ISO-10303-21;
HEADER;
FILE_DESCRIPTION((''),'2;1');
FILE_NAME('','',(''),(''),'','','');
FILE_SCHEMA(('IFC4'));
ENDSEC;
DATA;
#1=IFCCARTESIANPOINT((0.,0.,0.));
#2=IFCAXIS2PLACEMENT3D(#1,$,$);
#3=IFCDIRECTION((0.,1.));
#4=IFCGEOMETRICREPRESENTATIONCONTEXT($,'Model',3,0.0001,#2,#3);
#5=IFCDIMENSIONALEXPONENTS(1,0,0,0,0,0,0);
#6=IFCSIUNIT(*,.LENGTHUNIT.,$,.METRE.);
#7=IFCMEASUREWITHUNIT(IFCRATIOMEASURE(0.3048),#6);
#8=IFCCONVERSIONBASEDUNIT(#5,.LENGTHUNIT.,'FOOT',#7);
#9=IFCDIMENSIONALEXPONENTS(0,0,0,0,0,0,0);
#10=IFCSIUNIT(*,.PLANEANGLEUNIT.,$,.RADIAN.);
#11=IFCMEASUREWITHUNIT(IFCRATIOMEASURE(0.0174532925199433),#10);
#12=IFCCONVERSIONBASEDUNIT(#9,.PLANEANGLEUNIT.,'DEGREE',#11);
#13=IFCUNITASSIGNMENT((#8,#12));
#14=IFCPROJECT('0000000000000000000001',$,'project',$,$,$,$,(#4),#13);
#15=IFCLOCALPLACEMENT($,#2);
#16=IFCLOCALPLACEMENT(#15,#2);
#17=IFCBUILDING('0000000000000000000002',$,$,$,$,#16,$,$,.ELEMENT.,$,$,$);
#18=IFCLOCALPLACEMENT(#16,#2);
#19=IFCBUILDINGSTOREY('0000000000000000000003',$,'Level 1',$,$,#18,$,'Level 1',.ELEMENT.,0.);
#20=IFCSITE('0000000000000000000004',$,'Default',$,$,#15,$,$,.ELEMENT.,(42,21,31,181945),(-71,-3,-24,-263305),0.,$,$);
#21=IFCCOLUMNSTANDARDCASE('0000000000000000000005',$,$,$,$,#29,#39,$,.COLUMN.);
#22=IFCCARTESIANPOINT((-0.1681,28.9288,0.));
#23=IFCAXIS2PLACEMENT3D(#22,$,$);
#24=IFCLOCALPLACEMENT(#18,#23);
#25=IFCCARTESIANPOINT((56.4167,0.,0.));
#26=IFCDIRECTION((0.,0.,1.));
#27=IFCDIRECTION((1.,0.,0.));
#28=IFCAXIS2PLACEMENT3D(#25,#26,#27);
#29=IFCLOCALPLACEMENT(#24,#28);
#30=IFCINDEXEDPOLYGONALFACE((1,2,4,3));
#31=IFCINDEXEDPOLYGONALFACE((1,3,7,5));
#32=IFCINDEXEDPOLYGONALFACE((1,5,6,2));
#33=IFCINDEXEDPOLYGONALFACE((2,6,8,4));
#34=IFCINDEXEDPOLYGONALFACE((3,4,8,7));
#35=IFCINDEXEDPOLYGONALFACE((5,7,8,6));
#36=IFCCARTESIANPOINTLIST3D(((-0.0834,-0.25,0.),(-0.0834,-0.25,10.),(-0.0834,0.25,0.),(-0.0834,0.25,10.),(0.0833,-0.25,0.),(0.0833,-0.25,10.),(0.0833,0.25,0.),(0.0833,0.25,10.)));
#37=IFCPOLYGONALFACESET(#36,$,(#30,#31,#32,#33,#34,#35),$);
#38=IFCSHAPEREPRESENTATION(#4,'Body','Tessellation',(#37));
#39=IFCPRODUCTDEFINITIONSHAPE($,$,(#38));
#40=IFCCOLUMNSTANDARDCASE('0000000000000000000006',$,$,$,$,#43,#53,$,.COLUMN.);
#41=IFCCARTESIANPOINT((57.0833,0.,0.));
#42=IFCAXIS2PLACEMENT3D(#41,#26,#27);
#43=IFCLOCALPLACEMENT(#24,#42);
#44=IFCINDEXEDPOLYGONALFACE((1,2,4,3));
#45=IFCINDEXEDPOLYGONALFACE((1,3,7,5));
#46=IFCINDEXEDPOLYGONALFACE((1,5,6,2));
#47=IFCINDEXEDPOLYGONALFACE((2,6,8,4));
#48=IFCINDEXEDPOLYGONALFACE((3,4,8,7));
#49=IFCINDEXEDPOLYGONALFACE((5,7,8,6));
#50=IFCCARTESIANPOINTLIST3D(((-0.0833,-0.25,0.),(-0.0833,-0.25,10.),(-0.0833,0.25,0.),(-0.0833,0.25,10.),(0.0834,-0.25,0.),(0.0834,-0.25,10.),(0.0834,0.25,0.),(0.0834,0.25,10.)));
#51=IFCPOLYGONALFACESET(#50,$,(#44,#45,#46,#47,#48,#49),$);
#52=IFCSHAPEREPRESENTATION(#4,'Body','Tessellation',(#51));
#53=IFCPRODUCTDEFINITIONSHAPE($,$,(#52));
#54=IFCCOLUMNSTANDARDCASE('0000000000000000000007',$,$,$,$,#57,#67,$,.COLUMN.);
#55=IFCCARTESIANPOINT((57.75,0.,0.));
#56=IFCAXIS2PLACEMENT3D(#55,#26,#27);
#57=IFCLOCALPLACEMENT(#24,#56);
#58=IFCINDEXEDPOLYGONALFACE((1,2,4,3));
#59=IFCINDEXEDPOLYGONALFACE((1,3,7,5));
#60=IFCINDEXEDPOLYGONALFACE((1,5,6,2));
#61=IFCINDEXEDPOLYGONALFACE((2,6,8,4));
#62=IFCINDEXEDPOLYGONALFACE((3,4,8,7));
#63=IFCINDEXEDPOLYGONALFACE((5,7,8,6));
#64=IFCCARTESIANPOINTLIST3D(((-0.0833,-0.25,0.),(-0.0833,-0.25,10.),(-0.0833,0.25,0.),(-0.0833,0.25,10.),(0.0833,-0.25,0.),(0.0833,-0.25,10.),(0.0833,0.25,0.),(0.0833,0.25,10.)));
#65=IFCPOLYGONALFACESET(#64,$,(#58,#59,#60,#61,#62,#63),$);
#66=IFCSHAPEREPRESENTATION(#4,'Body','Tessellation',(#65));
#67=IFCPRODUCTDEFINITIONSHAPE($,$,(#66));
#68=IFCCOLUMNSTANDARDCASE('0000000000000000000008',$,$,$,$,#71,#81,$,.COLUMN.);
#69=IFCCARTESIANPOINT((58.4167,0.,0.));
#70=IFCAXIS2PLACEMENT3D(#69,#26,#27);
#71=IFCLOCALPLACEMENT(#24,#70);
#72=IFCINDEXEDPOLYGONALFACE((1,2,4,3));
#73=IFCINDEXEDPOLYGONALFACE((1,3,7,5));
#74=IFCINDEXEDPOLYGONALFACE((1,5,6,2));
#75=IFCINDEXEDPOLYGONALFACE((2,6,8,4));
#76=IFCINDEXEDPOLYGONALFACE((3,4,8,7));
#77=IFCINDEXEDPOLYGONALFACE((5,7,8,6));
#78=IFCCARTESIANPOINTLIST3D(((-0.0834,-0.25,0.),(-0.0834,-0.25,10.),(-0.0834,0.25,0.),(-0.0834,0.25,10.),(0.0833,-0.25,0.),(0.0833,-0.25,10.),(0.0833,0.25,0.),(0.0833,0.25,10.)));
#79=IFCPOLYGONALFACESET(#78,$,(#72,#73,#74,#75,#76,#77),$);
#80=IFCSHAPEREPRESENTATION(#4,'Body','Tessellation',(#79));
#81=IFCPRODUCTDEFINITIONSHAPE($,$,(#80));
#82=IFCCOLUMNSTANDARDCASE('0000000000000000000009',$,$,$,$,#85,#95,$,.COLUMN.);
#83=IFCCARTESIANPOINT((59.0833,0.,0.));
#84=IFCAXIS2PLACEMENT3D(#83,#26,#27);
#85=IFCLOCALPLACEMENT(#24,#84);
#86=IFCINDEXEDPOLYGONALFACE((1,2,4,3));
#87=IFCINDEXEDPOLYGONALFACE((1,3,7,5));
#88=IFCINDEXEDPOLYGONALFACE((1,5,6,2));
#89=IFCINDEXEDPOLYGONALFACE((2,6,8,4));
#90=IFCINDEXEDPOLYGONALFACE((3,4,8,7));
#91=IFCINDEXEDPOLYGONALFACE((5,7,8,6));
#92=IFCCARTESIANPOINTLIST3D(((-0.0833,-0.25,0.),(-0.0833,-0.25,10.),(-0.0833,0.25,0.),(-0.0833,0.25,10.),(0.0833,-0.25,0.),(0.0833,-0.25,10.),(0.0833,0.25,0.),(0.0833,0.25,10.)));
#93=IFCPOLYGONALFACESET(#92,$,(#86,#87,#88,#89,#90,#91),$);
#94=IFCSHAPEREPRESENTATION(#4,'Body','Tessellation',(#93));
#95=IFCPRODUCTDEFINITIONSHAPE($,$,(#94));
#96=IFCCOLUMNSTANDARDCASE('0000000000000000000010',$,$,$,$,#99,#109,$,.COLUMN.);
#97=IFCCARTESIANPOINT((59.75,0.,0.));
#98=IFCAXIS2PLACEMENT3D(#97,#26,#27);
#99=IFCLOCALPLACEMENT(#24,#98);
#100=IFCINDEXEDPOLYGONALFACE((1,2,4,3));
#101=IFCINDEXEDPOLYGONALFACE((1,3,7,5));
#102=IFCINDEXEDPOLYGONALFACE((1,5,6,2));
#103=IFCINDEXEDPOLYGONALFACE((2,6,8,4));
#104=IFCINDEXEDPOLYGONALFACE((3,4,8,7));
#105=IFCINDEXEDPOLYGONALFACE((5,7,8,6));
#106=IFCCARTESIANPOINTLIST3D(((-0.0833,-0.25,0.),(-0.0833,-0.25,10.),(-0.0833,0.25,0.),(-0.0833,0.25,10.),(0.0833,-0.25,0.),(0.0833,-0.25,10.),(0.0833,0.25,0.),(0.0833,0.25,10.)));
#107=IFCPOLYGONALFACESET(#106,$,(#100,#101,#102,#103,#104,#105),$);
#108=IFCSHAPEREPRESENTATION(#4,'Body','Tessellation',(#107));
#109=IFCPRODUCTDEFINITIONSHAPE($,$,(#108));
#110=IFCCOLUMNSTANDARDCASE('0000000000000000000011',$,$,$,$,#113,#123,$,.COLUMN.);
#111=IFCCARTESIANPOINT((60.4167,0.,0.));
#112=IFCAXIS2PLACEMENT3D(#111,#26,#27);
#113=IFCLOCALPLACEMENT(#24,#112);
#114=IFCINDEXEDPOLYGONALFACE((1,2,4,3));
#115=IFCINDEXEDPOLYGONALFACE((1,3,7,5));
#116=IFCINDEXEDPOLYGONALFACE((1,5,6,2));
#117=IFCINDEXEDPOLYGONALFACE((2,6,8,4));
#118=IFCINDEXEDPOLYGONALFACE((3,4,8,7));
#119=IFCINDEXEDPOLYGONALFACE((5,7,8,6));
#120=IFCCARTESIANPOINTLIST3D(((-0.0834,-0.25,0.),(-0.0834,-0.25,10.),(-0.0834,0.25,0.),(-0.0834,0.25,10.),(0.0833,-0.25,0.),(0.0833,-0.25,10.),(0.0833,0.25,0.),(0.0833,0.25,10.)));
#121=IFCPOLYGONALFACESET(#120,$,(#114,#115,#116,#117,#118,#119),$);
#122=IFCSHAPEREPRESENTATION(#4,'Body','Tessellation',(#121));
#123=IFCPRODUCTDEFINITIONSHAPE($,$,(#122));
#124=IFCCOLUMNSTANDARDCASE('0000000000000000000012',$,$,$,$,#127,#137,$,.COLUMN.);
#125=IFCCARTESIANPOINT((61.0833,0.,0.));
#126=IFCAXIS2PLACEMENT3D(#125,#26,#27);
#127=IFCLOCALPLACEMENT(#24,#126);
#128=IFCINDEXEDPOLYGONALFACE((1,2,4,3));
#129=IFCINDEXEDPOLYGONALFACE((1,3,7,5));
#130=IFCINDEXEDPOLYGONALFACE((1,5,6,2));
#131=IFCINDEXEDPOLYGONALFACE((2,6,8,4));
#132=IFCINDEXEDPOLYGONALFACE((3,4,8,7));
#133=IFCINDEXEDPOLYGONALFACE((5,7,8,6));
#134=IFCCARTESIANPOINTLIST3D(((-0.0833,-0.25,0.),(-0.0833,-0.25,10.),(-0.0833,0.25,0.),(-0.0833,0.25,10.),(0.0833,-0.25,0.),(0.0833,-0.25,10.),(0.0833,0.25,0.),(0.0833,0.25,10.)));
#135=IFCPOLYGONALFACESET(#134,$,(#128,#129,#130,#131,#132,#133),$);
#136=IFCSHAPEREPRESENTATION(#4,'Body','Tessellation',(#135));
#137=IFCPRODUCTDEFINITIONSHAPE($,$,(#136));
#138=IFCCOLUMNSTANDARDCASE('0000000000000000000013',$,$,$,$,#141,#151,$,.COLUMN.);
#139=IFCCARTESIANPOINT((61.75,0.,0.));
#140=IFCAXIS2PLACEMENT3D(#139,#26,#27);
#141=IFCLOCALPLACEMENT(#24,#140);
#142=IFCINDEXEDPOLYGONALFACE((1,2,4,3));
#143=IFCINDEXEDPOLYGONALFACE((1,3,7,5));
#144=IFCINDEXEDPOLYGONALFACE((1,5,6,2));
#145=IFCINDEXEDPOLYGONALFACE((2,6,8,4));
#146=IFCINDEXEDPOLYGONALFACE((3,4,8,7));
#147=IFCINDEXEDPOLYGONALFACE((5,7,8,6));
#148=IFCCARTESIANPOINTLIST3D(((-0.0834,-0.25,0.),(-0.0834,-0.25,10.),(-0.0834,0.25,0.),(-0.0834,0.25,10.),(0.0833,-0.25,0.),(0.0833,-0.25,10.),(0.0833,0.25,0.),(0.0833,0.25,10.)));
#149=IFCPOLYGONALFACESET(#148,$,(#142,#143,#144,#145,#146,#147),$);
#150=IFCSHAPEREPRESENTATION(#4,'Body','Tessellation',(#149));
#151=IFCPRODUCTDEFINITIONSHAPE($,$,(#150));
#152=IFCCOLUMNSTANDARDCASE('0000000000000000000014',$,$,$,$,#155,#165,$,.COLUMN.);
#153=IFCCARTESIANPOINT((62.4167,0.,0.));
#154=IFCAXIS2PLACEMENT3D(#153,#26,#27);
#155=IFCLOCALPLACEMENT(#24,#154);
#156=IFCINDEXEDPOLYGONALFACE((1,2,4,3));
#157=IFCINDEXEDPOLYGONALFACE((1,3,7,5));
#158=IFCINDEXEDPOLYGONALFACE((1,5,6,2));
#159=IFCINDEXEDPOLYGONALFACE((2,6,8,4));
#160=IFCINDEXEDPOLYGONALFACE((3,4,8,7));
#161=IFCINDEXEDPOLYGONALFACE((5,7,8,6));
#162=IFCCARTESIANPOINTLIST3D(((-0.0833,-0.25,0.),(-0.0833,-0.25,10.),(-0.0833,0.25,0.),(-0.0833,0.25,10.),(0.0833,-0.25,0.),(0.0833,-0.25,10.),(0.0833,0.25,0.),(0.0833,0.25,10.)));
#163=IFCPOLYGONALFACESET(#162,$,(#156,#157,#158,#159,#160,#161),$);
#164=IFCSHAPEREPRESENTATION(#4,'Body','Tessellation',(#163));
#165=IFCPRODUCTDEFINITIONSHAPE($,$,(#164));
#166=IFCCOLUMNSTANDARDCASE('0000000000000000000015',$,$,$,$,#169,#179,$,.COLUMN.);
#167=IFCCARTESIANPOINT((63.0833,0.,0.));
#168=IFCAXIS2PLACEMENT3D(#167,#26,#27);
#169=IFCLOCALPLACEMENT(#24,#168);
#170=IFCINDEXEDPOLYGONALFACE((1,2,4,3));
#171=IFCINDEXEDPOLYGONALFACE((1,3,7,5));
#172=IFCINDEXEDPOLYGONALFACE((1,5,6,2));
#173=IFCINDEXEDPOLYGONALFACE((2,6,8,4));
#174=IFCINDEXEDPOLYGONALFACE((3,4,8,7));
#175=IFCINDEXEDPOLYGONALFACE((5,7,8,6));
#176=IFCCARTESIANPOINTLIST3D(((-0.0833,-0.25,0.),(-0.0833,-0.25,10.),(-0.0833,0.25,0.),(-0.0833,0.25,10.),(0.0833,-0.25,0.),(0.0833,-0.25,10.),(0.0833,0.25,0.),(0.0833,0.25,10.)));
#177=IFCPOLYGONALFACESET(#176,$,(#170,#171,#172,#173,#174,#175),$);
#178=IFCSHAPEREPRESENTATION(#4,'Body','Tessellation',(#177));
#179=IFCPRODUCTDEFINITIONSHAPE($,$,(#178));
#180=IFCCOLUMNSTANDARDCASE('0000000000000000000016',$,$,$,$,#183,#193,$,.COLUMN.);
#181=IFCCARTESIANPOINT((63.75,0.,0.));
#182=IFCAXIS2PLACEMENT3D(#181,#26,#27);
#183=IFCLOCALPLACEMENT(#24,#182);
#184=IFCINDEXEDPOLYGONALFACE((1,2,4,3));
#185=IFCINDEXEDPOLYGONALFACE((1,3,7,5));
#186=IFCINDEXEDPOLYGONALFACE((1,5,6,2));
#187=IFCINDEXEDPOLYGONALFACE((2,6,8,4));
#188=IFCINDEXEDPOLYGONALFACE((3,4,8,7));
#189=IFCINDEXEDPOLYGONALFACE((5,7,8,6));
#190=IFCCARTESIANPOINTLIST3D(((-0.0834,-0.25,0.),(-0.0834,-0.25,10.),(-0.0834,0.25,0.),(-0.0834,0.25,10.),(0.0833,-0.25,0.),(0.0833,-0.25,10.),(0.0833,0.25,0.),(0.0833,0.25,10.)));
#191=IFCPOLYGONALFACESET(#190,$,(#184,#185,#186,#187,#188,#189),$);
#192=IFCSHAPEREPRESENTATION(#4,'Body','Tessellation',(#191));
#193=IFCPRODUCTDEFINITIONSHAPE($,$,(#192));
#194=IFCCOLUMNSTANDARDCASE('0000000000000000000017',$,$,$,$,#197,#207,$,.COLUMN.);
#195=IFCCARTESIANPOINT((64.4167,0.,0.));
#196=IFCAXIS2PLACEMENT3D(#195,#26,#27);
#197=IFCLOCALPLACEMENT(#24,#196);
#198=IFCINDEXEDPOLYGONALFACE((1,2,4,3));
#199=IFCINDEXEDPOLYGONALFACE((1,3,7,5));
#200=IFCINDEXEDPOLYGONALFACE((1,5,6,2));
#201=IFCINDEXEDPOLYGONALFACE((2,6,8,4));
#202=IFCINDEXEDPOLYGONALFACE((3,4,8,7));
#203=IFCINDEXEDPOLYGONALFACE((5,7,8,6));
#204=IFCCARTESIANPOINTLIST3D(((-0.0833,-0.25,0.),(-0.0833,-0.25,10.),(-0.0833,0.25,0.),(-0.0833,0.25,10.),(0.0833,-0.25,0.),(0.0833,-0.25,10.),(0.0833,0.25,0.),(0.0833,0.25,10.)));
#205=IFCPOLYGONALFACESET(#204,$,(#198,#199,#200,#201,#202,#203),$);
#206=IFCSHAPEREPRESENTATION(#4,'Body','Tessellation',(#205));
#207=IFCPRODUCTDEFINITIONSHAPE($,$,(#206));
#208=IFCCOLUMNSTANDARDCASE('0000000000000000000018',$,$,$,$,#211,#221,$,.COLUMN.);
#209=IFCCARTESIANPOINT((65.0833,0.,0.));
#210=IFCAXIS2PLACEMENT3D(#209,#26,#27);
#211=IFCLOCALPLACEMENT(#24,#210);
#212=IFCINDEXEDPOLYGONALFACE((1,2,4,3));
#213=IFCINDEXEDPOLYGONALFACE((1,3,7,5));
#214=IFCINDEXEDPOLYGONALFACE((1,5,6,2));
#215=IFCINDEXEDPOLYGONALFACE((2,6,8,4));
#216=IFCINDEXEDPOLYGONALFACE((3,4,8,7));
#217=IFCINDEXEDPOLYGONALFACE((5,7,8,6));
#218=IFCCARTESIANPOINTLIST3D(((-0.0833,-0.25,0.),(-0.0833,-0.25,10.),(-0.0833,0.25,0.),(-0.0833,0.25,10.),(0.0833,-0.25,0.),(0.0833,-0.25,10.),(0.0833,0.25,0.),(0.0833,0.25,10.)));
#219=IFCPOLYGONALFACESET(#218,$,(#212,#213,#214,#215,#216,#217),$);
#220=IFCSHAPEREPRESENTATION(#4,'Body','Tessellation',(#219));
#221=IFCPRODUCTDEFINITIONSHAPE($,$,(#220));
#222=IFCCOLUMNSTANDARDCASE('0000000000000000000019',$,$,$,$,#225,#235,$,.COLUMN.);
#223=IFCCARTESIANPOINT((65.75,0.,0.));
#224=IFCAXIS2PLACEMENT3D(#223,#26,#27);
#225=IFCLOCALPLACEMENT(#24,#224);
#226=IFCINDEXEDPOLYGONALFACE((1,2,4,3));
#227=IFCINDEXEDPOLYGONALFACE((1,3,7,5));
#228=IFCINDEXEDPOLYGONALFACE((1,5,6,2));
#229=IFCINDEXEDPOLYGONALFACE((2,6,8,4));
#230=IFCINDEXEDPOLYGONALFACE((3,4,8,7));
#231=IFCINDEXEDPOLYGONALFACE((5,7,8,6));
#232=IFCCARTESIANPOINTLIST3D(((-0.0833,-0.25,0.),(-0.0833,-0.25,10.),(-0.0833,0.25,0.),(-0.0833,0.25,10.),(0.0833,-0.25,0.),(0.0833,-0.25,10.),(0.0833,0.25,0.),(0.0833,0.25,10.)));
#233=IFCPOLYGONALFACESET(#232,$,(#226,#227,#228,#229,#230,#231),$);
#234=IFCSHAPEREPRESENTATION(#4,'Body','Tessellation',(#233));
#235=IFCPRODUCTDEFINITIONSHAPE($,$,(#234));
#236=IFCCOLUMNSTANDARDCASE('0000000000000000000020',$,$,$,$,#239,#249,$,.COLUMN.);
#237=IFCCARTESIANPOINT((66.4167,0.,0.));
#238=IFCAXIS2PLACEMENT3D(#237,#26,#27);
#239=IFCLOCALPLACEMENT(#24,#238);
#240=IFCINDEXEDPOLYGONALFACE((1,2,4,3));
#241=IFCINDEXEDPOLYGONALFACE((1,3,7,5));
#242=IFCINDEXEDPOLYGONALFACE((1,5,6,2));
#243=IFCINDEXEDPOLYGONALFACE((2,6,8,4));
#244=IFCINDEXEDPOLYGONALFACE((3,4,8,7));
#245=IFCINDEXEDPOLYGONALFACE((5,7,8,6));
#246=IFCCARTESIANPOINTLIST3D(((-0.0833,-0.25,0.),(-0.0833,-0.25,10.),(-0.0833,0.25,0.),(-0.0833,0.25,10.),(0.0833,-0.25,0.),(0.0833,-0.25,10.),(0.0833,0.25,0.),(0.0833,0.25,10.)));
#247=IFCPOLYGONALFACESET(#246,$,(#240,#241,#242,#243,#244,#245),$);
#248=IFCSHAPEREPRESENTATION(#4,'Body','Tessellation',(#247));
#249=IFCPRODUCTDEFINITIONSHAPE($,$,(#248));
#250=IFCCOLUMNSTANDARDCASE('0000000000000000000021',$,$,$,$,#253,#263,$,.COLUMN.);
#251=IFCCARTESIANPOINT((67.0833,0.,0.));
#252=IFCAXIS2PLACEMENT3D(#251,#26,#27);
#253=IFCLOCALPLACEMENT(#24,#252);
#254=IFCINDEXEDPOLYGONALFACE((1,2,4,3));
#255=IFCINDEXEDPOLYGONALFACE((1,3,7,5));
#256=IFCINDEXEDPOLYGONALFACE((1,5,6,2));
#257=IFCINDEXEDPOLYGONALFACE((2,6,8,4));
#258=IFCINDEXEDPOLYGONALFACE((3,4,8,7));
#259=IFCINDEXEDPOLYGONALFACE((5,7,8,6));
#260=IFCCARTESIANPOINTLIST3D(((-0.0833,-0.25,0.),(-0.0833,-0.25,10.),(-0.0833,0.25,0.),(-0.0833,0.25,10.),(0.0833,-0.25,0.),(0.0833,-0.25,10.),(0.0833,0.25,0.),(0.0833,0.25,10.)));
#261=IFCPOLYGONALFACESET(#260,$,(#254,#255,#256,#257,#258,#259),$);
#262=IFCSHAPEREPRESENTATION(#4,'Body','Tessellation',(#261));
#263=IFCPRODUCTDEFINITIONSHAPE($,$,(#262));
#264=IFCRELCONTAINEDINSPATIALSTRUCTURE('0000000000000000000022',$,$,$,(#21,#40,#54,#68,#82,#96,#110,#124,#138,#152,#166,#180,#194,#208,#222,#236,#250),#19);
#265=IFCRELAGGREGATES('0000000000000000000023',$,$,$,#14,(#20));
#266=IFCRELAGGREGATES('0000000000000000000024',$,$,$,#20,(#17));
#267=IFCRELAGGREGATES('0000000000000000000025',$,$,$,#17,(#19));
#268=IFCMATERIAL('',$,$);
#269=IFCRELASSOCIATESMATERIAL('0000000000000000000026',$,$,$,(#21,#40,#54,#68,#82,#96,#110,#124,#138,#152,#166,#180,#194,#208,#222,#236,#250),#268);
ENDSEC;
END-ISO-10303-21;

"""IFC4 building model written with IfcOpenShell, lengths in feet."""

from ifc_helpers import new_model, entity, si_unit, converted_unit, direction, frame, origin, place, context, project, spatial, rectangle, extrude, material, element, save


model = new_model("IFC4")

# Units and contexts
model_context = context("Model", 3, precision=0.0001, world=origin(), true_north=direction((0.0, 1.0)))
ifc_project = project(units=[converted_unit("LENGTHUNIT", "FOOT", entity("IfcRatioMeasure", 0.3048), si_unit("LENGTHUNIT", "METRE"), dimensions=[1, 0, 0, 0, 0, 0, 0]), converted_unit("PLANEANGLEUNIT", "DEGREE", entity("IfcRatioMeasure", 0.0174532925199433), si_unit("PLANEANGLEUNIT", "RADIAN"), dimensions=[0, 0, 0, 0, 0, 0, 0])], contexts=[model_context])

# Site, building, storey
site_placement = place(None, origin())
site = spatial("IfcSite", under=ifc_project, at=site_placement, Name="Default", CompositionType="ELEMENT", RefLatitude=(42, 21, 31, 181945), RefLongitude=(-71, -3, -24, -263305), RefElevation=0.0)
building_placement = place(site_placement, origin())
building = spatial("IfcBuilding", under=site, at=building_placement, CompositionType="ELEMENT")
storey_placement = place(building_placement, origin())
storey = spatial("IfcBuildingStorey", under=building, at=storey_placement, Name="Level 1", LongName="Level 1", CompositionType="ELEMENT", Elevation=0.0)

# Columns
ifc_material_1 = material(Name="")
placement = place(storey_placement, frame((-0.1681, 28.9288, 0.0)))
for number, where, z_axis, x_axis in (
    (1, (56.4167, 0.0, 0.0), (0.0, 0.0, 1.0), (1.0, 0.0, 0.0)),
    (2, (57.0833, 0.0, 0.0), (0.0, 0.0, 1.0), (1.0, 0.0, 0.0)),
    (3, (57.75, 0.0, 0.0), (0.0, 0.0, 1.0), (1.0, 0.0, 0.0)),
    (4, (58.4167, 0.0, 0.0), (0.0, 0.0, 1.0), (1.0, 0.0, 0.0)),
    (5, (59.0833, 0.0, 0.0), (0.0, 0.0, 1.0), (1.0, 0.0, 0.0)),
    (6, (59.75, 0.0, 0.0), (0.0, 0.0, 1.0), (1.0, 0.0, 0.0)),
    (7, (60.4167, 0.0, 0.0), (0.0, 0.0, 1.0), (1.0, 0.0, 0.0)),
    (8, (61.0833, 0.0, 0.0), (0.0, 0.0, 1.0), (1.0, 0.0, 0.0)),
    (9, (61.75, 0.0, 0.0), (0.0, 0.0, 1.0), (1.0, 0.0, 0.0)),
    (10, (62.4167, 0.0, 0.0), (0.0, 0.0, 1.0), (1.0, 0.0, 0.0)),
    (11, (63.0833, 0.0, 0.0), (0.0, 0.0, 1.0), (1.0, 0.0, 0.0)),
    (12, (63.75, 0.0, 0.0), (0.0, 0.0, 1.0), (1.0, 0.0, 0.0)),
    (13, (64.4167, 0.0, 0.0), (0.0, 0.0, 1.0), (1.0, 0.0, 0.0)),
    (14, (65.0833, 0.0, 0.0), (0.0, 0.0, 1.0), (1.0, 0.0, 0.0)),
    (15, (65.75, 0.0, 0.0), (0.0, 0.0, 1.0), (1.0, 0.0, 0.0)),
    (16, (66.4167, 0.0, 0.0), (0.0, 0.0, 1.0), (1.0, 0.0, 0.0)),
    (17, (67.0833, 0.0, 0.0), (0.0, 0.0, 1.0), (1.0, 0.0, 0.0)),
):
    element("IfcColumnStandardCase", number, at=place(placement, frame(where, z_axis=z_axis, x_axis=x_axis)), inside=storey, material=ifc_material_1, PredefinedType="COLUMN", context=model_context, shape_type="SweptSolid", body=[
        extrude(rectangle(XDim=0.1667, YDim=0.5), origin(), (0.0, 0.0, 1.0), 10.0),
    ])

save(model, "model.ifc")
